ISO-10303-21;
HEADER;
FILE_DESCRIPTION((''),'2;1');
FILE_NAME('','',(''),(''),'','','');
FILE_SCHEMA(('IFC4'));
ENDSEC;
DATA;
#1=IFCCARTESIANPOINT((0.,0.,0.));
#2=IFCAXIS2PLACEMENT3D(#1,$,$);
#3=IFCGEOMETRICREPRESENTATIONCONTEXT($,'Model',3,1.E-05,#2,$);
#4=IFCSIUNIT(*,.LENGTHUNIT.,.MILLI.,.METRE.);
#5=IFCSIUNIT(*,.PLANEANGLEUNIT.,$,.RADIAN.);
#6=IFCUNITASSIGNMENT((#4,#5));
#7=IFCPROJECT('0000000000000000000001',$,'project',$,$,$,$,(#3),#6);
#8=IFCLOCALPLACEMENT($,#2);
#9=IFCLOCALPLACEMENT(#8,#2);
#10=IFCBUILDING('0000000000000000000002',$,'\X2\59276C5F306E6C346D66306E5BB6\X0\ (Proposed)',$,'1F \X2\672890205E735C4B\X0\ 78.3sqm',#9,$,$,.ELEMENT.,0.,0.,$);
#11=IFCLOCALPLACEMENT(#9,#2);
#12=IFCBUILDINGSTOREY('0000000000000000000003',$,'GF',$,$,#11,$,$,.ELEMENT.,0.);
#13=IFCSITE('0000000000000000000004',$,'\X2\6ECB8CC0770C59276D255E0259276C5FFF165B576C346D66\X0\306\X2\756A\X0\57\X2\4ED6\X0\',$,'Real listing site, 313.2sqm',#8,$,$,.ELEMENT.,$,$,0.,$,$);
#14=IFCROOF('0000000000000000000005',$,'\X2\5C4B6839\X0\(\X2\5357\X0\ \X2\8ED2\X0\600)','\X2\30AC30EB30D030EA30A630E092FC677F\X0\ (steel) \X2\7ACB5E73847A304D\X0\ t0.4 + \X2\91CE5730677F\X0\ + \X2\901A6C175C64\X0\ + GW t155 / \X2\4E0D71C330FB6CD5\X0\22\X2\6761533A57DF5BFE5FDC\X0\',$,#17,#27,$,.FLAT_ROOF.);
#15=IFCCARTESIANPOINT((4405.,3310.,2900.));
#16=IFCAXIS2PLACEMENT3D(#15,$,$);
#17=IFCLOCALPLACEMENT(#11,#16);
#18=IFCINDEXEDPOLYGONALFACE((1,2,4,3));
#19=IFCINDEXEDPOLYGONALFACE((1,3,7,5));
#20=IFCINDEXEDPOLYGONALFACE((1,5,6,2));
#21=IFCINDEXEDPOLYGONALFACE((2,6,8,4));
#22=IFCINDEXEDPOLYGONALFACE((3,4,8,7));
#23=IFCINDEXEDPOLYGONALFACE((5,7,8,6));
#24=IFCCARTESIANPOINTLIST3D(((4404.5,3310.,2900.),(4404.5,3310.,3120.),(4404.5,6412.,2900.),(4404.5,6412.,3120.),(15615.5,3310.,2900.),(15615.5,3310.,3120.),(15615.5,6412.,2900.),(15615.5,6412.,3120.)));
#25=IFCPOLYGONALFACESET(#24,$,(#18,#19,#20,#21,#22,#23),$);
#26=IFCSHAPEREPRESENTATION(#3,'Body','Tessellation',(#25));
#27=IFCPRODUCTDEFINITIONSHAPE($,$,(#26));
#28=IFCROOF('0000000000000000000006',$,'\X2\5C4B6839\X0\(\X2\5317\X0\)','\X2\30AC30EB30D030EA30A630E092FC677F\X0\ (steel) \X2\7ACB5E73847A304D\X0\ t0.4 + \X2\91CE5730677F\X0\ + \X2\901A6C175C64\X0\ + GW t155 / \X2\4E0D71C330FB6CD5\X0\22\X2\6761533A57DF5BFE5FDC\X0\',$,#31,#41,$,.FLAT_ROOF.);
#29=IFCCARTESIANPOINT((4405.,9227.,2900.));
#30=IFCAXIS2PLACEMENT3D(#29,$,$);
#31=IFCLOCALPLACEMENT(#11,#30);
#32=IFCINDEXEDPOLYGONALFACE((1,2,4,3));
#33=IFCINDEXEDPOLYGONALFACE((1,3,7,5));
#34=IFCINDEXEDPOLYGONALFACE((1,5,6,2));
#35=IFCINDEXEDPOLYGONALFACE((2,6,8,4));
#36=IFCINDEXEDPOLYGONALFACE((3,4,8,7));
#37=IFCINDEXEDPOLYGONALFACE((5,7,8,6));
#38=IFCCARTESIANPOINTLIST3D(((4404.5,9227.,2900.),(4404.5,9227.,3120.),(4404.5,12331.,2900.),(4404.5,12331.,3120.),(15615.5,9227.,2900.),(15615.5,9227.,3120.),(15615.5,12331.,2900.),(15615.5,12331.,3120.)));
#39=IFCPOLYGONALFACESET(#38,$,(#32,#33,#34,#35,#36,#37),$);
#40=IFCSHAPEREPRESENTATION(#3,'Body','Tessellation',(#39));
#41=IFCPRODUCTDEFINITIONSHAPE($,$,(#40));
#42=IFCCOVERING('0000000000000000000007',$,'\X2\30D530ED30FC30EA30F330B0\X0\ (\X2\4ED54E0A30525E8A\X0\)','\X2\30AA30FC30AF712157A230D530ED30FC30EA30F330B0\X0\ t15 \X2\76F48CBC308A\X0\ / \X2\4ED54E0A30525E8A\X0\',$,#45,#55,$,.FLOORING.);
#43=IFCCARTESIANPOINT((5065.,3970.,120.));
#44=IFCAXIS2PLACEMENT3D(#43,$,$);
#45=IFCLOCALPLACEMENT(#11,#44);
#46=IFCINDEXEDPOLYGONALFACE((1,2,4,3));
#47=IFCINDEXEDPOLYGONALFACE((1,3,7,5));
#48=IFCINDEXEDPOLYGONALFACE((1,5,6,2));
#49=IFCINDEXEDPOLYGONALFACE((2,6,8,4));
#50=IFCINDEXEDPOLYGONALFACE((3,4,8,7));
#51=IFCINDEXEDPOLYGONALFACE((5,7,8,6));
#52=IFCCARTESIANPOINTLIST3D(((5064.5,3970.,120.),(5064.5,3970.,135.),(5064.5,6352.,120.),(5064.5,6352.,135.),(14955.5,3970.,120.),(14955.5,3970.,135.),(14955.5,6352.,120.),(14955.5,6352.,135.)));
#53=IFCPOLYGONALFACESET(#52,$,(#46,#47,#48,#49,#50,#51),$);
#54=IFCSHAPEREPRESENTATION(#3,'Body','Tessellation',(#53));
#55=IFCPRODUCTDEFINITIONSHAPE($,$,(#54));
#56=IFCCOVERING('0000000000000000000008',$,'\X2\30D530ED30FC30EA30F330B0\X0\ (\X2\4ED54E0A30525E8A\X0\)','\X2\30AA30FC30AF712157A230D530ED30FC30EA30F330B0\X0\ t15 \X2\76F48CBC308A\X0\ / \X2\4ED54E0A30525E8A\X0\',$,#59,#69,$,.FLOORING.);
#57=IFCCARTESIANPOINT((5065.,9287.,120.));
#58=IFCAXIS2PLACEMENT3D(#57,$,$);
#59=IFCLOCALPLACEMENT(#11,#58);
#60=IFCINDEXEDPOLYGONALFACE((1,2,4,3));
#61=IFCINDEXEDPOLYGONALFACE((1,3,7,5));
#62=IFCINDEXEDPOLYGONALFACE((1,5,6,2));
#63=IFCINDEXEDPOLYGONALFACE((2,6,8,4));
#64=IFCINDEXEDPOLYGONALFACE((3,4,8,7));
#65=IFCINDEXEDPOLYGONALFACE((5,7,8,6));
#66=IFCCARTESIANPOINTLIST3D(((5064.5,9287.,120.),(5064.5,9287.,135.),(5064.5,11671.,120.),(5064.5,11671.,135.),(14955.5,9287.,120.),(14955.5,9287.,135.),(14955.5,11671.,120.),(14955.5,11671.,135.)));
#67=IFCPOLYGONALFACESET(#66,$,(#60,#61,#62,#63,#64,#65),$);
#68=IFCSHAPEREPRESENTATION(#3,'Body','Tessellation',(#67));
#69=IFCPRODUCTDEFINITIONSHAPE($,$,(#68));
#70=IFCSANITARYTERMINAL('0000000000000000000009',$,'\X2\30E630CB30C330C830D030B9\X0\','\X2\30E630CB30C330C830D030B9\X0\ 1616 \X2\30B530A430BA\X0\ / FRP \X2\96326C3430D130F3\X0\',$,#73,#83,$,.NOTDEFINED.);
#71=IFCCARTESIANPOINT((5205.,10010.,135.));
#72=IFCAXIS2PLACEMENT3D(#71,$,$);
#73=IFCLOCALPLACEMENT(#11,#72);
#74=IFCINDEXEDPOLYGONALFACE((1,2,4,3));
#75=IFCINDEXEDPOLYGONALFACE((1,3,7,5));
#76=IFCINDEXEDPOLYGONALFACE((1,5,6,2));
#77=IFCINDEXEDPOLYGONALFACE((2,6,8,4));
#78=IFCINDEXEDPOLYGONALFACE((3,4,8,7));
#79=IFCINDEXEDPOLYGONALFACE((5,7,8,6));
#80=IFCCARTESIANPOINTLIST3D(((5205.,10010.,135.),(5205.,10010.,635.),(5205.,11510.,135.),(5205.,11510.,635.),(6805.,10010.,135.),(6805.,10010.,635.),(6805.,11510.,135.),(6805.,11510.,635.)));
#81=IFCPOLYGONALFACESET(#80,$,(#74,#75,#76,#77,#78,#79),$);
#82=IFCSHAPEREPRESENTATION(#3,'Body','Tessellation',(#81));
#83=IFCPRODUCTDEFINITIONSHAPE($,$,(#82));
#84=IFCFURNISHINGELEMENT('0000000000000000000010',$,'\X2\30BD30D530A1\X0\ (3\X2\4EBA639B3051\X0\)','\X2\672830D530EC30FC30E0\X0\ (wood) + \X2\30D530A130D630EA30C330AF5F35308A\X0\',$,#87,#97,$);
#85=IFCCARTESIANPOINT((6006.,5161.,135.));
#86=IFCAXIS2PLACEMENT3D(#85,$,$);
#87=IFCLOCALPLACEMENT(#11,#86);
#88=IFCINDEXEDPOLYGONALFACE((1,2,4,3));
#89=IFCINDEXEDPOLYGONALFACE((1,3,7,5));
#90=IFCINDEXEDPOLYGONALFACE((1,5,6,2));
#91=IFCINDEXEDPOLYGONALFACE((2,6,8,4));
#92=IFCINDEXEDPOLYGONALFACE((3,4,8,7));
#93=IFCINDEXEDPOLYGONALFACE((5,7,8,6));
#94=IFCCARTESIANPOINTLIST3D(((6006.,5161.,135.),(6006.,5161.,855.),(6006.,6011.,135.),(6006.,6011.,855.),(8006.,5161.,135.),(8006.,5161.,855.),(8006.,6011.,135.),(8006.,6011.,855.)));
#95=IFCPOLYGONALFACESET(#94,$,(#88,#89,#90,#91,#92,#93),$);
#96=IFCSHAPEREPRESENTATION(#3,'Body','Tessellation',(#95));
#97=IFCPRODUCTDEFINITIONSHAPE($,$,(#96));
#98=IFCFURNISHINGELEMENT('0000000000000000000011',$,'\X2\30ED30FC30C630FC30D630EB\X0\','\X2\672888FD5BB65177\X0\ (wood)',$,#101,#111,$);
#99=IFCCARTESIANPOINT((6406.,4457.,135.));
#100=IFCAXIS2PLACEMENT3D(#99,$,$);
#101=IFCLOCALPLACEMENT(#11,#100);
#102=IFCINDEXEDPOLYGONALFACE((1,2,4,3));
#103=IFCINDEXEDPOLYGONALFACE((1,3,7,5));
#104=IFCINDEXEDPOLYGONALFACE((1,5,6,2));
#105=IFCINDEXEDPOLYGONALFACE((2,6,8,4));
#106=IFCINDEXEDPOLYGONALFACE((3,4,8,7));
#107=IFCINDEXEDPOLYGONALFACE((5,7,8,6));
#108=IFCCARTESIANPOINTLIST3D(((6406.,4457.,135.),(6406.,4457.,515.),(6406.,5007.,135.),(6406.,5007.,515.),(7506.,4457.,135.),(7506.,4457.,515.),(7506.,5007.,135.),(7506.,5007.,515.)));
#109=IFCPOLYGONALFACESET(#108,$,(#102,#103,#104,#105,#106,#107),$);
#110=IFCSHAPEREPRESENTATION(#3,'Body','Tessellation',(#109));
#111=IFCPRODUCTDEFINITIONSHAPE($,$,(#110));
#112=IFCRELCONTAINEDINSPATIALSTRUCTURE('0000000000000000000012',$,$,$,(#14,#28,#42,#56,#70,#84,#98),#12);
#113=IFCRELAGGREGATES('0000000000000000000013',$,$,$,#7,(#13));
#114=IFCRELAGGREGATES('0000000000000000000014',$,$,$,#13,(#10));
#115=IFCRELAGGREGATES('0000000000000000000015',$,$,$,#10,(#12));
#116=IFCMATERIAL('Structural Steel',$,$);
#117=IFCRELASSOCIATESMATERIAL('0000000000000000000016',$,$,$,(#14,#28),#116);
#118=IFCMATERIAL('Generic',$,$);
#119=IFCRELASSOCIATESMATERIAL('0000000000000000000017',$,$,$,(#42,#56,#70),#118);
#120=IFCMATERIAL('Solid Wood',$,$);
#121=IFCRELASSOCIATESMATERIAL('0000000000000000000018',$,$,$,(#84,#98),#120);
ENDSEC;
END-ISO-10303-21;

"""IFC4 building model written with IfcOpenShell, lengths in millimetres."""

from ifc_helpers import new_model, si_unit, frame, frame_2d, origin, place, context, project, spatial, rectangle, extrude, material, element, save


model = new_model("IFC4")

# Units and contexts
model_context = context("Model", 3, precision=1e-05, world=origin())
ifc_project = project(units=[si_unit("LENGTHUNIT", "METRE", prefix="MILLI"), si_unit("PLANEANGLEUNIT", "RADIAN")], contexts=[model_context])

# Site, building, storey
site_placement = place(None, origin())
site = spatial("IfcSite", under=ifc_project, at=site_placement, Name="滋賀県大津市大江６字水浦306番57他", ObjectType="Real listing site, 313.2sqm", CompositionType="ELEMENT", RefElevation=0.0)
building_placement = place(site_placement, origin())
building = spatial("IfcBuilding", under=site, at=building_placement, Name="大江の水浦の家 (Proposed)", ObjectType="1F 木造平屋 78.3sqm", CompositionType="ELEMENT", ElevationOfRefHeight=0.0, ElevationOfTerrain=0.0)
storey_placement = place(building_placement, origin())
storey = spatial("IfcBuildingStorey", under=building, at=storey_placement, Name="GF", CompositionType="ELEMENT", Elevation=0.0)

# Shared definitions
ifc_material_1 = material(Name="Solid Wood")

# Roofs
ifc_material_2 = material(Name="Structural Steel")
roof_1_placement = place(storey_placement, frame((4405.0, 3310.0, 2900.0)))
element("IfcRoof", 1, at=roof_1_placement, inside=storey, material=ifc_material_2, Name="屋根(南 軒600)", Description="ガルバリウム鋼板 (steel) 立平葺き t0.4 + 野地板 + 通気層 + GW t155 / 不燃・法22条区域対応", PredefinedType="FLAT_ROOF", context=model_context, shape_type="SweptSolid", body=[
    extrude(rectangle(XDim=11211.0, YDim=3102.0, at=frame_2d((5605.0, 1551.0))), frame((4405.0, 3310.0, 2900.0)), (0.0, 0.0, 1.0), 220.0),
])
roof_2_placement = place(storey_placement, frame((4405.0, 9227.0, 2900.0)))
element("IfcRoof", 2, at=roof_2_placement, inside=storey, material=ifc_material_2, Name="屋根(北)", Description="ガルバリウム鋼板 (steel) 立平葺き t0.4 + 野地板 + 通気層 + GW t155 / 不燃・法22条区域対応", PredefinedType="FLAT_ROOF", context=model_context, shape_type="SweptSolid", body=[
    extrude(rectangle(XDim=11211.0, YDim=3104.0, at=frame_2d((5605.0, 1552.0))), frame((4405.0, 9227.0, 2900.0)), (0.0, 0.0, 1.0), 220.0),
])

# Coverings
ifc_material_3 = material(Name="Generic")
covering_1_placement = place(storey_placement, frame((5065.0, 3970.0, 120.0)))
element("IfcCovering", 3, at=covering_1_placement, inside=storey, material=ifc_material_3, Name="フローリング (仕上げ床)", Description="オーク無垢フローリング t15 直貼り / 仕上げ床", PredefinedType="FLOORING", context=model_context, shape_type="SweptSolid", body=[
    extrude(rectangle(XDim=9891.0, YDim=2382.0, at=frame_2d((4945.0, 1191.0))), frame((5065.0, 3970.0, 120.0)), (0.0, 0.0, 1.0), 15.0),
])
covering_2_placement = place(storey_placement, frame((5065.0, 9287.0, 120.0)))
element("IfcCovering", 4, at=covering_2_placement, inside=storey, material=ifc_material_3, Name="フローリング (仕上げ床)", Description="オーク無垢フローリング t15 直貼り / 仕上げ床", PredefinedType="FLOORING", context=model_context, shape_type="SweptSolid", body=[
    extrude(rectangle(XDim=9891.0, YDim=2384.0, at=frame_2d((4945.0, 1192.0))), frame((5065.0, 9287.0, 120.0)), (0.0, 0.0, 1.0), 15.0),
])

# Sanitary terminal
sanitary_terminal_placement = place(storey_placement, frame((5205.0, 10010.0, 135.0)))
element("IfcSanitaryTerminal", 5, at=sanitary_terminal_placement, inside=storey, material=ifc_material_3, Name="ユニットバス", Description="ユニットバス 1616 サイズ / FRP 防水パン", PredefinedType="NOTDEFINED", context=model_context, shape_type="SweptSolid", body=[
    extrude(rectangle(XDim=1600.0, YDim=1500.0, at=frame_2d((800.0, 750.0))), frame((5205.0, 10010.0, 135.0)), (0.0, 0.0, 1.0), 500.0),
])

# Furnishing elements
furnishing_1_placement = place(storey_placement, frame((6006.0, 5161.0, 135.0)))
element("IfcFurnishingElement", 6, at=furnishing_1_placement, inside=storey, material=ifc_material_1, Name="ソファ (3人掛け)", Description="木フレーム (wood) + ファブリック張り", context=model_context, shape_type="SweptSolid", body=[
    extrude(rectangle(XDim=2000.0, YDim=850.0, at=frame_2d((1000.0, 425.0))), frame((6006.0, 5161.0, 135.0)), (0.0, 0.0, 1.0), 720.0),
])
furnishing_2_placement = place(storey_placement, frame((6406.0, 4457.0, 135.0)))
element("IfcFurnishingElement", 7, at=furnishing_2_placement, inside=storey, material=ifc_material_1, Name="ローテーブル", Description="木製家具 (wood)", context=model_context, shape_type="SweptSolid", body=[
    extrude(rectangle(XDim=1100.0, YDim=550.0, at=frame_2d((550.0, 275.0))), frame((6406.0, 4457.0, 135.0)), (0.0, 0.0, 1.0), 380.0),
])

save(model, "model.ifc")
